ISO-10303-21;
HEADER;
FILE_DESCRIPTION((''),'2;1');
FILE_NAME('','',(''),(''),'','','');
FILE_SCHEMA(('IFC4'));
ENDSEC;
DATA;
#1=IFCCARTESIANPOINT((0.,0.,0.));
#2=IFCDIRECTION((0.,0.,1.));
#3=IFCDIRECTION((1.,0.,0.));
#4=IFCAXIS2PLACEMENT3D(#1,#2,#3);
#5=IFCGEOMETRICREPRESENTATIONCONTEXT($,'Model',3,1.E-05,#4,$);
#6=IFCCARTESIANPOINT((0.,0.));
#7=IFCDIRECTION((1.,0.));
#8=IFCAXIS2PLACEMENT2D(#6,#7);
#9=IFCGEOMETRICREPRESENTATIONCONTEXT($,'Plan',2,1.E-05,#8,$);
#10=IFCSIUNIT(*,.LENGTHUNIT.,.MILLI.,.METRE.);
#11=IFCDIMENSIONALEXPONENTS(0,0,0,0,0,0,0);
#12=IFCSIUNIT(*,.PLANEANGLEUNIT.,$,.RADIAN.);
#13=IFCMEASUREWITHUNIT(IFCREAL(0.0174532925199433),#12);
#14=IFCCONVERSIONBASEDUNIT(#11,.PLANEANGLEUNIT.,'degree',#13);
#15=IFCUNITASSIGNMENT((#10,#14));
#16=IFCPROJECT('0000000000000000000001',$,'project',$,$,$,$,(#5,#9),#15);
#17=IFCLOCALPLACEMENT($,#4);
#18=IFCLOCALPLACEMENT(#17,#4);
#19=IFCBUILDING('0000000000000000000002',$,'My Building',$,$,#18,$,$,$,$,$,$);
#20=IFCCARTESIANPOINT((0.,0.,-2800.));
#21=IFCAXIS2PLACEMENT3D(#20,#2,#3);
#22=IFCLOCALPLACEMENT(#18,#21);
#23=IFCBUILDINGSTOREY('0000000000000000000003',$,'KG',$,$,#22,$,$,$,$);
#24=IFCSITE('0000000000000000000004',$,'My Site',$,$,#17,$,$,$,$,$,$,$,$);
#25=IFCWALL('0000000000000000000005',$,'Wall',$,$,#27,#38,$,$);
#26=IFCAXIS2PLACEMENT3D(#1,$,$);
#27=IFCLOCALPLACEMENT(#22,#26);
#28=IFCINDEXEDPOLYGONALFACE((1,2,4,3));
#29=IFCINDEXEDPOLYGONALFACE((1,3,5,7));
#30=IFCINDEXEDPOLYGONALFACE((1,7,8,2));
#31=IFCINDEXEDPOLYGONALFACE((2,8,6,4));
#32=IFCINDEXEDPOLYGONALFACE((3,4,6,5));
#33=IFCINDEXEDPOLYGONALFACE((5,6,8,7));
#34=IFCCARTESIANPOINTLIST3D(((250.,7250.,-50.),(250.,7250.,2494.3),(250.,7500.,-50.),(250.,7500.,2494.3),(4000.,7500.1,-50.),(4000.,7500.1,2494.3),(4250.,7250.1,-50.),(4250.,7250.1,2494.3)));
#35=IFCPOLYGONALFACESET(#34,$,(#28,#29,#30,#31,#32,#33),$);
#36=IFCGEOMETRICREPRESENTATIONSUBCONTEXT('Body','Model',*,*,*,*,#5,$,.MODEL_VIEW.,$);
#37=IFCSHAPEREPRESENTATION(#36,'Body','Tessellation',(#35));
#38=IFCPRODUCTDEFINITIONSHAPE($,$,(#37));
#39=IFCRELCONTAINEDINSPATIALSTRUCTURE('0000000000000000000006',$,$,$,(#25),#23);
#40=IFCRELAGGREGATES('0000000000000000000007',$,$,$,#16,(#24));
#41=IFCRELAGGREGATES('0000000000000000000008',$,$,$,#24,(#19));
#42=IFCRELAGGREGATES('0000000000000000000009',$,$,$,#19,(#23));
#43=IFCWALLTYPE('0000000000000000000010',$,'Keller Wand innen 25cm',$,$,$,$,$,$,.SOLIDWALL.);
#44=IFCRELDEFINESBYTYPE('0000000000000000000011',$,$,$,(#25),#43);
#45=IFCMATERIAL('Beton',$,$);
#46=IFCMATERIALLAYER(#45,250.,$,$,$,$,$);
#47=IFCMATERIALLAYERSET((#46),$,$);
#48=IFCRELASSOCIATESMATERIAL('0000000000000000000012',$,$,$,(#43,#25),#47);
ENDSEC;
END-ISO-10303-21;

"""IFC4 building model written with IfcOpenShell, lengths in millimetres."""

from ifc_helpers import new_model, entity, si_unit, converted_unit, frame, origin_with_axes, origin_2d_with_axis, place, context, subcontext, project, spatial, line, indexed_curve, outline, extrude, material, layer, layer_set, layer_usage, type_object, element, save


model = new_model("IFC4")

# Units and contexts
model_context = context("Model", 3, precision=1e-05, world=origin_with_axes())
plan_context = context("Plan", 2, precision=1e-05, world=origin_2d_with_axis())
body_context = subcontext(model_context, "Body", "Model", "MODEL_VIEW")
ifc_project = project(units=[si_unit("LENGTHUNIT", "METRE", prefix="MILLI"), converted_unit("PLANEANGLEUNIT", "degree", entity("IfcReal", 0.0174532925199433), si_unit("PLANEANGLEUNIT", "RADIAN"), dimensions=[0, 0, 0, 0, 0, 0, 0])], contexts=[model_context, plan_context])

# Site, building, storey
site_placement = place(None, origin_with_axes())
site = spatial("IfcSite", under=ifc_project, at=site_placement, Name="My Site")
building_placement = place(site_placement, origin_with_axes())
building = spatial("IfcBuilding", under=site, at=building_placement, Name="My Building")
storey_placement = place(building_placement, frame((0.0, 0.0, -2800.0), z_axis=(0.0, 0.0, 1.0), x_axis=(1.0, 0.0, 0.0)))
storey = spatial("IfcBuildingStorey", under=building, at=storey_placement, Name="KG")

# Shared definitions
ifc_material_1 = material(Name="Beton")

# Wall
ifc_layer_1 = layer(ifc_material_1, 250.0)
ifc_layer_set_1 = layer_set([ifc_layer_1])
wall_type_1 = type_object("IfcWallType", Name="Keller Wand innen 25cm", PredefinedType="SOLIDWALL", material=ifc_layer_set_1)
ifc_layer_usage_1 = layer_usage(ifc_layer_set_1, "AXIS2", "POSITIVE", 0.0)
wall_1_placement = place(storey_placement, frame((250.0, 7250.0, -50.0), z_axis=(0.0, 0.0, 1.0), x_axis=(1.0, 0.000018, 0.0)))
element("IfcWall", 1, at=wall_1_placement, inside=storey, type_object=wall_type_1, material=ifc_layer_usage_1, Name="Wall", context=body_context, shape_type="SweptSolid", body=[
    extrude(outline(indexed_curve([(0.0, 0.0), (0.0, 250.0), (3750.0, 250.0), (4000.0, 0.0)], segments=[line(1, 2, 3, 4, 1)])), origin_with_axes(), (0.0, 0.0, 1.0), 2544.3),
])

save(model, "model.ifc")
